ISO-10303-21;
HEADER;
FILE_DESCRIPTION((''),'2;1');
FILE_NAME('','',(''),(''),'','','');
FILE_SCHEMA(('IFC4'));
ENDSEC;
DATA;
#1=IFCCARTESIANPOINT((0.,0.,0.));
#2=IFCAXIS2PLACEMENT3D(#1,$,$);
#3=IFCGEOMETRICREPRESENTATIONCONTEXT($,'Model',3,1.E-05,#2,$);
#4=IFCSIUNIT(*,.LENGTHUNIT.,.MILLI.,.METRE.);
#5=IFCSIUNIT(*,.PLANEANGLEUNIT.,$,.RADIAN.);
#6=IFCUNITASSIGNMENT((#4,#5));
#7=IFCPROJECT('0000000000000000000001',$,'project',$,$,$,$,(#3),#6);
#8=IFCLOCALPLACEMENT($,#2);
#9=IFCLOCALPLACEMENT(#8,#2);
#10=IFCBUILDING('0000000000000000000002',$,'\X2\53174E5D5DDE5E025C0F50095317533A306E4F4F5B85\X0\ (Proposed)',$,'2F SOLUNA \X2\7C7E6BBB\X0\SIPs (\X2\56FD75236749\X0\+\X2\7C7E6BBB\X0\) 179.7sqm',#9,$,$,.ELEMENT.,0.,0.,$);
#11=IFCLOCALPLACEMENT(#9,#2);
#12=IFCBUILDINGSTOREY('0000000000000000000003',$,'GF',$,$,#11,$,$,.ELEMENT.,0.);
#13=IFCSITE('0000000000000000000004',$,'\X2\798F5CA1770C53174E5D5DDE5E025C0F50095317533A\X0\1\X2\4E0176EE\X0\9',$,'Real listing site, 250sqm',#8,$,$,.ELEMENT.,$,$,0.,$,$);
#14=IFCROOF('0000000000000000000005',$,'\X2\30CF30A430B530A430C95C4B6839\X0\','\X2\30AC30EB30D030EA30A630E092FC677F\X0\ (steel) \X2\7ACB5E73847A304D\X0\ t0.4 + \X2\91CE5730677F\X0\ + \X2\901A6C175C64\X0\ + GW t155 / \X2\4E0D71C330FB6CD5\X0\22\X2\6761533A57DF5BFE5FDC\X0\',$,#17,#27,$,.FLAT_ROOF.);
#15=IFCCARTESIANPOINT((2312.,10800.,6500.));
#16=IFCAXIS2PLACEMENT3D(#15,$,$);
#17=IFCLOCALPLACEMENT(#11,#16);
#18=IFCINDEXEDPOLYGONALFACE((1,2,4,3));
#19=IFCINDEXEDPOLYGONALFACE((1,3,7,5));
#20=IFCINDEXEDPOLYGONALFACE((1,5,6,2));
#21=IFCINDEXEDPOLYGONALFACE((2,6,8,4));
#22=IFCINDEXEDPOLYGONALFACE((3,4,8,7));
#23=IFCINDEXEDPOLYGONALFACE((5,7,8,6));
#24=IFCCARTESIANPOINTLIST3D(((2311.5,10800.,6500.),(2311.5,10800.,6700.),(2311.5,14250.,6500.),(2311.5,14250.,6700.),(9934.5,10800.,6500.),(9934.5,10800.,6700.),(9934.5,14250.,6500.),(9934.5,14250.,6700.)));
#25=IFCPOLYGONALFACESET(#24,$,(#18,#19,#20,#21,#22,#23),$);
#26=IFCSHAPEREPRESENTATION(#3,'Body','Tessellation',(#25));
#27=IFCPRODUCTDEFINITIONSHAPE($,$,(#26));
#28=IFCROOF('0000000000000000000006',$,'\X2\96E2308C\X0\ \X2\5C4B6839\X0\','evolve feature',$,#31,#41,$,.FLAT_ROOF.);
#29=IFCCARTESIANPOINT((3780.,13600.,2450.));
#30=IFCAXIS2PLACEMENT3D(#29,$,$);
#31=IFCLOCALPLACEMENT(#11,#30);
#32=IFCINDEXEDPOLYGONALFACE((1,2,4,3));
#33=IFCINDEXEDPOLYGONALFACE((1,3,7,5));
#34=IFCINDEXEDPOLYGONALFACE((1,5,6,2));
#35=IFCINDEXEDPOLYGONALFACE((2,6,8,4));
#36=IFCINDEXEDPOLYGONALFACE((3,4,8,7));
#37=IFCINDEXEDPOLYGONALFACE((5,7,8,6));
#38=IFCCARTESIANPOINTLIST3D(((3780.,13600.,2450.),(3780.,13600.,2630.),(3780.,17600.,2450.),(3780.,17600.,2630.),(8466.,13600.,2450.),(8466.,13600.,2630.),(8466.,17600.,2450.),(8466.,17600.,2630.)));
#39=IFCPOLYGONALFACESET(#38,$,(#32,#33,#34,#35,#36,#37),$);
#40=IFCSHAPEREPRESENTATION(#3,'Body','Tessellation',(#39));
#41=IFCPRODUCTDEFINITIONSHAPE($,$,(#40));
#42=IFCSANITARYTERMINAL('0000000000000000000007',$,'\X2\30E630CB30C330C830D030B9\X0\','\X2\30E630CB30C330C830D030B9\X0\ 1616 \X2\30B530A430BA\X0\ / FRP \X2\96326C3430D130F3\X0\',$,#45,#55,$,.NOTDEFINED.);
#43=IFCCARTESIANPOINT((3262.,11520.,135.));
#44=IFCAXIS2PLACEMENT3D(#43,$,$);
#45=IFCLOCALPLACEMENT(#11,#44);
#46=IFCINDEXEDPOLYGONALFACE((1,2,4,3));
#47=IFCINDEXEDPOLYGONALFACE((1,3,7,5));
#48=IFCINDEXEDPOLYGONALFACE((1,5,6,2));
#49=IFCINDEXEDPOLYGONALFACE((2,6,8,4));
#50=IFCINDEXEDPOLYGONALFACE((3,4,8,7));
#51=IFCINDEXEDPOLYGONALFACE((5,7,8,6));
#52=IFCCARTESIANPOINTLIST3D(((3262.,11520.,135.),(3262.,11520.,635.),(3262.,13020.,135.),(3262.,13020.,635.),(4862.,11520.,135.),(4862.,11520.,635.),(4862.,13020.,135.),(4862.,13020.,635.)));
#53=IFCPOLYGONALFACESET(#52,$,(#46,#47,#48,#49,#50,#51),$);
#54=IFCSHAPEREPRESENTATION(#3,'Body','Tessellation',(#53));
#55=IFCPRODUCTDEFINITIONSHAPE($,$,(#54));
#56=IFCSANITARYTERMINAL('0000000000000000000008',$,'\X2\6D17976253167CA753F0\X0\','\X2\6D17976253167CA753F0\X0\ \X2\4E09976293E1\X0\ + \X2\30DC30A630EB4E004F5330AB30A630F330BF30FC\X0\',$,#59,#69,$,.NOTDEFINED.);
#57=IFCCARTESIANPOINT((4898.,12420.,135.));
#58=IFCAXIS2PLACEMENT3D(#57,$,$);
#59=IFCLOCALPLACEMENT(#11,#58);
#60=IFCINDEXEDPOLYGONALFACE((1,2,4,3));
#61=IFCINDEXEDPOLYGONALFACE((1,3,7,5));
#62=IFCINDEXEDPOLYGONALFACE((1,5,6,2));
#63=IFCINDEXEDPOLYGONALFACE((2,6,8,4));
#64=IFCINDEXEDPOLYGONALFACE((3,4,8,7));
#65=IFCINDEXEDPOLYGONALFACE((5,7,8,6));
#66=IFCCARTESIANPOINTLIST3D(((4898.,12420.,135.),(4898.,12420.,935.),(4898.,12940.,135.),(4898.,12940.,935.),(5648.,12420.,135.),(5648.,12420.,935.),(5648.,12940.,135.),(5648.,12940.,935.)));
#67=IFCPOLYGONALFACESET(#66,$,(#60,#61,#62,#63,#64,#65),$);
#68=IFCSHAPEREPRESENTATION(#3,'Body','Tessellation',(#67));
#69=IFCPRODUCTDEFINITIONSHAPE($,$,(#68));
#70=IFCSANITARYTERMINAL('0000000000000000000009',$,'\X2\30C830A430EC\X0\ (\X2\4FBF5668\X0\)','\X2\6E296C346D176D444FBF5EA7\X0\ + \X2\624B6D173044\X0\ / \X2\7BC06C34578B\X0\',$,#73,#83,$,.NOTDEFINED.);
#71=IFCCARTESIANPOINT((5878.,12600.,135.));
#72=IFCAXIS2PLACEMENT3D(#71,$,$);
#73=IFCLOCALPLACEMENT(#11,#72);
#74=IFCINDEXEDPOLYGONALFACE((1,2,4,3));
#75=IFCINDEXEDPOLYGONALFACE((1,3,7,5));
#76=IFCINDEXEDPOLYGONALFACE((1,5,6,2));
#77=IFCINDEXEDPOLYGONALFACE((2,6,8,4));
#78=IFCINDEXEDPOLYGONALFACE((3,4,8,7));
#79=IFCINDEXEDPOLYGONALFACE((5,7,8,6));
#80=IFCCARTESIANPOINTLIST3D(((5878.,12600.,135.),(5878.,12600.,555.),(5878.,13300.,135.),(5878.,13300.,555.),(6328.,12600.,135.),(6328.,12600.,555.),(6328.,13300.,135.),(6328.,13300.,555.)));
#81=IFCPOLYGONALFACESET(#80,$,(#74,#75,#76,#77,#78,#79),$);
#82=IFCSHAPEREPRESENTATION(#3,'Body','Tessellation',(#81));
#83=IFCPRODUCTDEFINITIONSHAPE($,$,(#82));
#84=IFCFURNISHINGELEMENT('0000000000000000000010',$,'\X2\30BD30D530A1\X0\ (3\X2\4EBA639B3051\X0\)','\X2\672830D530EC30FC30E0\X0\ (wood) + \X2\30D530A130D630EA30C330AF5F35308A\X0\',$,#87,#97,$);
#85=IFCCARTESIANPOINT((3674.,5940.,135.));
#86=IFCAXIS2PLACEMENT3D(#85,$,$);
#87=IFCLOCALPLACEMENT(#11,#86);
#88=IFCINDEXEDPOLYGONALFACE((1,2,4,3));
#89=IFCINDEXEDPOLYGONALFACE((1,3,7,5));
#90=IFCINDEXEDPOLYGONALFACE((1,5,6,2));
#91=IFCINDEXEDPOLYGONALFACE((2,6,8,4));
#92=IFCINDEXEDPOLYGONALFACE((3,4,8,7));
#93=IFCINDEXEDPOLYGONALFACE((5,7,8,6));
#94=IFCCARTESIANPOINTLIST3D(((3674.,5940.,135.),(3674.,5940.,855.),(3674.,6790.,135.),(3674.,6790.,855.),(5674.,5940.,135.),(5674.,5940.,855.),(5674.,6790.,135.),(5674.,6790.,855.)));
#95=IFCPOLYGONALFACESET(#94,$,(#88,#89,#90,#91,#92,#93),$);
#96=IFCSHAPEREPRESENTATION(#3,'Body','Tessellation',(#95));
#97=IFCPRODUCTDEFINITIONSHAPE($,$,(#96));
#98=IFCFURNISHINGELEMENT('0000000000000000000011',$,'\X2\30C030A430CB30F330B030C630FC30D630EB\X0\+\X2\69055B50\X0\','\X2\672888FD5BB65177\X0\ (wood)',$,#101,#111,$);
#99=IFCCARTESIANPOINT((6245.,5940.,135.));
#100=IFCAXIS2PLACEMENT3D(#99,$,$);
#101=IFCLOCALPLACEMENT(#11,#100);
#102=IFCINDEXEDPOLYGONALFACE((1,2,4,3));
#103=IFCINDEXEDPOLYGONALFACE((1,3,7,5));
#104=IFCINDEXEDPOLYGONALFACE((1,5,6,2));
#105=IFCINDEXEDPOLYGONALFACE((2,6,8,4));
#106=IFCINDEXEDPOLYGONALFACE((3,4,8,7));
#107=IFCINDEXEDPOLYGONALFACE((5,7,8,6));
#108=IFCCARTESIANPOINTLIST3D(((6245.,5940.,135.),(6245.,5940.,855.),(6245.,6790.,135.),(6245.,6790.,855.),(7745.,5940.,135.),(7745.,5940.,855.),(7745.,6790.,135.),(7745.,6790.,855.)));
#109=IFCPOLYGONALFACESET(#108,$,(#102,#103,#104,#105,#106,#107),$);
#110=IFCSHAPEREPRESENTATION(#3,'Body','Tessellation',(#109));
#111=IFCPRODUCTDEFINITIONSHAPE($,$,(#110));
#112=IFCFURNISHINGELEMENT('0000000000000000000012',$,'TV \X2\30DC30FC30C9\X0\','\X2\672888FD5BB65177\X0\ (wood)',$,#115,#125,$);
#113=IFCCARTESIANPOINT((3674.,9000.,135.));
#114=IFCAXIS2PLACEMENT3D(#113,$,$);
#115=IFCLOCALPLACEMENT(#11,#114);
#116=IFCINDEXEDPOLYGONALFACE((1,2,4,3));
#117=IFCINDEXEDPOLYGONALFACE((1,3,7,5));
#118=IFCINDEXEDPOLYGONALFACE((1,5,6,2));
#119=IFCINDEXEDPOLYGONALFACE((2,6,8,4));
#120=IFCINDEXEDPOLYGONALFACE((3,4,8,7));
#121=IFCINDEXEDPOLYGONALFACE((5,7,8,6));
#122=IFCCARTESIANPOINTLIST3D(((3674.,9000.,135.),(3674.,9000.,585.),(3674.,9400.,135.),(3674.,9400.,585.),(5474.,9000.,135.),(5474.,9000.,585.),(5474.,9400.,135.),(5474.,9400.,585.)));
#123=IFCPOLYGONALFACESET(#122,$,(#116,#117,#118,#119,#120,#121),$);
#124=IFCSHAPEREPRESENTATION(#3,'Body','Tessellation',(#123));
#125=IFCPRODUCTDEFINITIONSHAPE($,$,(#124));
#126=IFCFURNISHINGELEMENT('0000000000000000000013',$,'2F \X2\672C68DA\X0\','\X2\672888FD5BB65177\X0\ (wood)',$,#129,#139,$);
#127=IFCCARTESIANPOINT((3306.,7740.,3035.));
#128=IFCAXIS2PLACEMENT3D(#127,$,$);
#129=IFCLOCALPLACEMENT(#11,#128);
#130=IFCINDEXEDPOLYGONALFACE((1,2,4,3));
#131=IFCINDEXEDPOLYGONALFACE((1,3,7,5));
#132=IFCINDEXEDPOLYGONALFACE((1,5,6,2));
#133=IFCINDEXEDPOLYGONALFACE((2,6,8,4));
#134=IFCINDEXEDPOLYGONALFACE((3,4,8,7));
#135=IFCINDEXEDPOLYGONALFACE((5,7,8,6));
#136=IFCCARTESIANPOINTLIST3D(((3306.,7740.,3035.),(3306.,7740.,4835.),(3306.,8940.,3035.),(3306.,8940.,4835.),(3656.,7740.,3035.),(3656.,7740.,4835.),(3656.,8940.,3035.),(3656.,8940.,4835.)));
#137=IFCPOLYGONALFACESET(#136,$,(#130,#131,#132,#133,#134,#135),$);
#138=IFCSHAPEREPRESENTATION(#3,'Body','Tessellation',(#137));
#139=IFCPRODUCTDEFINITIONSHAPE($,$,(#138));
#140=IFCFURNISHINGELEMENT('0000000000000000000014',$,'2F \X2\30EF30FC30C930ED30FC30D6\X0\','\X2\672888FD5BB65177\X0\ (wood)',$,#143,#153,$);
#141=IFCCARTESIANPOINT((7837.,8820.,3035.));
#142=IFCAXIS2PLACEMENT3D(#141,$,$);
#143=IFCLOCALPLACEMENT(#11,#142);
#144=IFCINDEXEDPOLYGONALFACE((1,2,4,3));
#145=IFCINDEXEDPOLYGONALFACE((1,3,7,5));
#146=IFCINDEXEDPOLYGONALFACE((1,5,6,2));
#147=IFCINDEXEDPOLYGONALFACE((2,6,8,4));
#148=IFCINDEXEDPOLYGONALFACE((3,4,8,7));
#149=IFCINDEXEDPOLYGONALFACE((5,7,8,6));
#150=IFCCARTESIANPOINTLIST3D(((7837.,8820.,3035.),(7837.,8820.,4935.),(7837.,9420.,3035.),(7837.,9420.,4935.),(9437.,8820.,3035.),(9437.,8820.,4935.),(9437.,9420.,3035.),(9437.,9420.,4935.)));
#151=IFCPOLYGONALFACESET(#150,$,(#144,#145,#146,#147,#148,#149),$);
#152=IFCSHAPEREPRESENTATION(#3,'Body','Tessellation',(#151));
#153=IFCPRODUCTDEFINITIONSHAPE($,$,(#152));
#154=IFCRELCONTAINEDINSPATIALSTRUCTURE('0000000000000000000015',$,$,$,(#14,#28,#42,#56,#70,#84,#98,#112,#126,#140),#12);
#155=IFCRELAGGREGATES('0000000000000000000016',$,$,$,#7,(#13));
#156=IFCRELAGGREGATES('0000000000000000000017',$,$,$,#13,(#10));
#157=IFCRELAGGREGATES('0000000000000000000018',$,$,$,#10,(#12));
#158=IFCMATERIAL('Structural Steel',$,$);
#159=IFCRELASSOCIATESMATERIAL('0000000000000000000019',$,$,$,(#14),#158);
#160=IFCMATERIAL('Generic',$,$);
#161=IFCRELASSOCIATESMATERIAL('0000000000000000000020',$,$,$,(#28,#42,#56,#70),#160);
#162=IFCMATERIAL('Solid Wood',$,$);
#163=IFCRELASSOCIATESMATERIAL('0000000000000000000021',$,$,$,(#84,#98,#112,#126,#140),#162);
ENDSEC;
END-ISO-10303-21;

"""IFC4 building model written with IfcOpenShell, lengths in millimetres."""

from ifc_helpers import new_model, si_unit, frame, frame_2d, origin, place, context, project, spatial, rectangle, extrude, material, element, save


model = new_model("IFC4")

# Units and contexts
model_context = context("Model", 3, precision=1e-05, world=origin())
ifc_project = project(units=[si_unit("LENGTHUNIT", "METRE", prefix="MILLI"), si_unit("PLANEANGLEUNIT", "RADIAN")], contexts=[model_context])

# Site, building, storey
site_placement = place(None, origin())
site = spatial("IfcSite", under=ifc_project, at=site_placement, Name="福岡県北九州市小倉北区1丁目9", ObjectType="Real listing site, 250sqm", CompositionType="ELEMENT", RefElevation=0.0)
building_placement = place(site_placement, origin())
building = spatial("IfcBuilding", under=site, at=building_placement, Name="北九州市小倉北区の住宅 (Proposed)", ObjectType="2F SOLUNA 籾殻SIPs (国産杉+籾殻) 179.7sqm", CompositionType="ELEMENT", ElevationOfRefHeight=0.0, ElevationOfTerrain=0.0)
storey_placement = place(building_placement, origin())
storey = spatial("IfcBuildingStorey", under=building, at=storey_placement, Name="GF", CompositionType="ELEMENT", Elevation=0.0)

# Shared definitions
ifc_material_1 = material(Name="Generic")

# Shared definitions
ifc_material_2 = material(Name="Solid Wood")

# Roofs
ifc_material_3 = material(Name="Structural Steel")
roof_1_placement = place(storey_placement, frame((2312.0, 10800.0, 6500.0)))
element("IfcRoof", 1, at=roof_1_placement, inside=storey, material=ifc_material_3, Name="ハイサイド屋根", Description="ガルバリウム鋼板 (steel) 立平葺き t0.4 + 野地板 + 通気層 + GW t155 / 不燃・法22条区域対応", PredefinedType="FLAT_ROOF", context=model_context, shape_type="SweptSolid", body=[
    extrude(rectangle(XDim=7623.0, YDim=3450.0, at=frame_2d((3811.0, 1725.0))), frame((2312.0, 10800.0, 6500.0)), (0.0, 0.0, 1.0), 200.0),
])
roof_2_placement = place(storey_placement, frame((3780.0, 13600.0, 2450.0)))
element("IfcRoof", 2, at=roof_2_placement, inside=storey, material=ifc_material_1, Name="離れ 屋根", Description="evolve feature", PredefinedType="FLAT_ROOF", context=model_context, shape_type="SweptSolid", body=[
    extrude(rectangle(XDim=4686.0, YDim=4000.0, at=frame_2d((2343.0, 2000.0))), frame((3780.0, 13600.0, 2450.0)), (0.0, 0.0, 1.0), 180.0),
])

# Sanitary terminals
sanitary_terminal_1_placement = place(storey_placement, frame((3262.0, 11520.0, 135.0)))
element("IfcSanitaryTerminal", 3, at=sanitary_terminal_1_placement, inside=storey, material=ifc_material_1, Name="ユニットバス", Description="ユニットバス 1616 サイズ / FRP 防水パン", PredefinedType="NOTDEFINED", context=model_context, shape_type="SweptSolid", body=[
    extrude(rectangle(XDim=1600.0, YDim=1500.0, at=frame_2d((800.0, 750.0))), frame((3262.0, 11520.0, 135.0)), (0.0, 0.0, 1.0), 500.0),
])
sanitary_terminal_2_placement = place(storey_placement, frame((4898.0, 12420.0, 135.0)))
element("IfcSanitaryTerminal", 4, at=sanitary_terminal_2_placement, inside=storey, material=ifc_material_1, Name="洗面化粧台", Description="洗面化粧台 三面鏡 + ボウル一体カウンター", PredefinedType="NOTDEFINED", context=model_context, shape_type="SweptSolid", body=[
    extrude(rectangle(XDim=750.0, YDim=520.0, at=frame_2d((375.0, 260.0))), frame((4898.0, 12420.0, 135.0)), (0.0, 0.0, 1.0), 800.0),
])
sanitary_terminal_3_placement = place(storey_placement, frame((5878.0, 12600.0, 135.0)))
element("IfcSanitaryTerminal", 5, at=sanitary_terminal_3_placement, inside=storey, material=ifc_material_1, Name="トイレ (便器)", Description="温水洗浄便座 + 手洗い / 節水型", PredefinedType="NOTDEFINED", context=model_context, shape_type="SweptSolid", body=[
    extrude(rectangle(XDim=450.0, YDim=700.0, at=frame_2d((225.0, 350.0))), frame((5878.0, 12600.0, 135.0)), (0.0, 0.0, 1.0), 420.0),
])

# Furnishing elements
furnishing_1_placement = place(storey_placement, frame((3674.0, 5940.0, 135.0)))
element("IfcFurnishingElement", 6, at=furnishing_1_placement, inside=storey, material=ifc_material_2, Name="ソファ (3人掛け)", Description="木フレーム (wood) + ファブリック張り", context=model_context, shape_type="SweptSolid", body=[
    extrude(rectangle(XDim=2000.0, YDim=850.0, at=frame_2d((1000.0, 425.0))), frame((3674.0, 5940.0, 135.0)), (0.0, 0.0, 1.0), 720.0),
])
furnishing_2_placement = place(storey_placement, frame((6245.0, 5940.0, 135.0)))
element("IfcFurnishingElement", 7, at=furnishing_2_placement, inside=storey, material=ifc_material_2, Name="ダイニングテーブル+椅子", Description="木製家具 (wood)", context=model_context, shape_type="SweptSolid", body=[
    extrude(rectangle(XDim=1500.0, YDim=850.0, at=frame_2d((750.0, 425.0))), frame((6245.0, 5940.0, 135.0)), (0.0, 0.0, 1.0), 720.0),
])
furnishing_3_placement = place(storey_placement, frame((3674.0, 9000.0, 135.0)))
element("IfcFurnishingElement", 8, at=furnishing_3_placement, inside=storey, material=ifc_material_2, Name="TV ボード", Description="木製家具 (wood)", context=model_context, shape_type="SweptSolid", body=[
    extrude(rectangle(XDim=1800.0, YDim=400.0, at=frame_2d((900.0, 200.0))), frame((3674.0, 9000.0, 135.0)), (0.0, 0.0, 1.0), 450.0),
])
furnishing_4_placement = place(storey_placement, frame((3306.0, 7740.0, 3035.0)))
element("IfcFurnishingElement", 9, at=furnishing_4_placement, inside=storey, material=ifc_material_2, Name="2F 本棚", Description="木製家具 (wood)", context=model_context, shape_type="SweptSolid", body=[
    extrude(rectangle(XDim=350.0, YDim=1200.0, at=frame_2d((175.0, 600.0))), frame((3306.0, 7740.0, 3035.0)), (0.0, 0.0, 1.0), 1800.0),
])
furnishing_5_placement = place(storey_placement, frame((7837.0, 8820.0, 3035.0)))
element("IfcFurnishingElement", 10, at=furnishing_5_placement, inside=storey, material=ifc_material_2, Name="2F ワードローブ", Description="木製家具 (wood)", context=model_context, shape_type="SweptSolid", body=[
    extrude(rectangle(XDim=1600.0, YDim=600.0, at=frame_2d((800.0, 300.0))), frame((7837.0, 8820.0, 3035.0)), (0.0, 0.0, 1.0), 1900.0),
])

save(model, "model.ifc")
